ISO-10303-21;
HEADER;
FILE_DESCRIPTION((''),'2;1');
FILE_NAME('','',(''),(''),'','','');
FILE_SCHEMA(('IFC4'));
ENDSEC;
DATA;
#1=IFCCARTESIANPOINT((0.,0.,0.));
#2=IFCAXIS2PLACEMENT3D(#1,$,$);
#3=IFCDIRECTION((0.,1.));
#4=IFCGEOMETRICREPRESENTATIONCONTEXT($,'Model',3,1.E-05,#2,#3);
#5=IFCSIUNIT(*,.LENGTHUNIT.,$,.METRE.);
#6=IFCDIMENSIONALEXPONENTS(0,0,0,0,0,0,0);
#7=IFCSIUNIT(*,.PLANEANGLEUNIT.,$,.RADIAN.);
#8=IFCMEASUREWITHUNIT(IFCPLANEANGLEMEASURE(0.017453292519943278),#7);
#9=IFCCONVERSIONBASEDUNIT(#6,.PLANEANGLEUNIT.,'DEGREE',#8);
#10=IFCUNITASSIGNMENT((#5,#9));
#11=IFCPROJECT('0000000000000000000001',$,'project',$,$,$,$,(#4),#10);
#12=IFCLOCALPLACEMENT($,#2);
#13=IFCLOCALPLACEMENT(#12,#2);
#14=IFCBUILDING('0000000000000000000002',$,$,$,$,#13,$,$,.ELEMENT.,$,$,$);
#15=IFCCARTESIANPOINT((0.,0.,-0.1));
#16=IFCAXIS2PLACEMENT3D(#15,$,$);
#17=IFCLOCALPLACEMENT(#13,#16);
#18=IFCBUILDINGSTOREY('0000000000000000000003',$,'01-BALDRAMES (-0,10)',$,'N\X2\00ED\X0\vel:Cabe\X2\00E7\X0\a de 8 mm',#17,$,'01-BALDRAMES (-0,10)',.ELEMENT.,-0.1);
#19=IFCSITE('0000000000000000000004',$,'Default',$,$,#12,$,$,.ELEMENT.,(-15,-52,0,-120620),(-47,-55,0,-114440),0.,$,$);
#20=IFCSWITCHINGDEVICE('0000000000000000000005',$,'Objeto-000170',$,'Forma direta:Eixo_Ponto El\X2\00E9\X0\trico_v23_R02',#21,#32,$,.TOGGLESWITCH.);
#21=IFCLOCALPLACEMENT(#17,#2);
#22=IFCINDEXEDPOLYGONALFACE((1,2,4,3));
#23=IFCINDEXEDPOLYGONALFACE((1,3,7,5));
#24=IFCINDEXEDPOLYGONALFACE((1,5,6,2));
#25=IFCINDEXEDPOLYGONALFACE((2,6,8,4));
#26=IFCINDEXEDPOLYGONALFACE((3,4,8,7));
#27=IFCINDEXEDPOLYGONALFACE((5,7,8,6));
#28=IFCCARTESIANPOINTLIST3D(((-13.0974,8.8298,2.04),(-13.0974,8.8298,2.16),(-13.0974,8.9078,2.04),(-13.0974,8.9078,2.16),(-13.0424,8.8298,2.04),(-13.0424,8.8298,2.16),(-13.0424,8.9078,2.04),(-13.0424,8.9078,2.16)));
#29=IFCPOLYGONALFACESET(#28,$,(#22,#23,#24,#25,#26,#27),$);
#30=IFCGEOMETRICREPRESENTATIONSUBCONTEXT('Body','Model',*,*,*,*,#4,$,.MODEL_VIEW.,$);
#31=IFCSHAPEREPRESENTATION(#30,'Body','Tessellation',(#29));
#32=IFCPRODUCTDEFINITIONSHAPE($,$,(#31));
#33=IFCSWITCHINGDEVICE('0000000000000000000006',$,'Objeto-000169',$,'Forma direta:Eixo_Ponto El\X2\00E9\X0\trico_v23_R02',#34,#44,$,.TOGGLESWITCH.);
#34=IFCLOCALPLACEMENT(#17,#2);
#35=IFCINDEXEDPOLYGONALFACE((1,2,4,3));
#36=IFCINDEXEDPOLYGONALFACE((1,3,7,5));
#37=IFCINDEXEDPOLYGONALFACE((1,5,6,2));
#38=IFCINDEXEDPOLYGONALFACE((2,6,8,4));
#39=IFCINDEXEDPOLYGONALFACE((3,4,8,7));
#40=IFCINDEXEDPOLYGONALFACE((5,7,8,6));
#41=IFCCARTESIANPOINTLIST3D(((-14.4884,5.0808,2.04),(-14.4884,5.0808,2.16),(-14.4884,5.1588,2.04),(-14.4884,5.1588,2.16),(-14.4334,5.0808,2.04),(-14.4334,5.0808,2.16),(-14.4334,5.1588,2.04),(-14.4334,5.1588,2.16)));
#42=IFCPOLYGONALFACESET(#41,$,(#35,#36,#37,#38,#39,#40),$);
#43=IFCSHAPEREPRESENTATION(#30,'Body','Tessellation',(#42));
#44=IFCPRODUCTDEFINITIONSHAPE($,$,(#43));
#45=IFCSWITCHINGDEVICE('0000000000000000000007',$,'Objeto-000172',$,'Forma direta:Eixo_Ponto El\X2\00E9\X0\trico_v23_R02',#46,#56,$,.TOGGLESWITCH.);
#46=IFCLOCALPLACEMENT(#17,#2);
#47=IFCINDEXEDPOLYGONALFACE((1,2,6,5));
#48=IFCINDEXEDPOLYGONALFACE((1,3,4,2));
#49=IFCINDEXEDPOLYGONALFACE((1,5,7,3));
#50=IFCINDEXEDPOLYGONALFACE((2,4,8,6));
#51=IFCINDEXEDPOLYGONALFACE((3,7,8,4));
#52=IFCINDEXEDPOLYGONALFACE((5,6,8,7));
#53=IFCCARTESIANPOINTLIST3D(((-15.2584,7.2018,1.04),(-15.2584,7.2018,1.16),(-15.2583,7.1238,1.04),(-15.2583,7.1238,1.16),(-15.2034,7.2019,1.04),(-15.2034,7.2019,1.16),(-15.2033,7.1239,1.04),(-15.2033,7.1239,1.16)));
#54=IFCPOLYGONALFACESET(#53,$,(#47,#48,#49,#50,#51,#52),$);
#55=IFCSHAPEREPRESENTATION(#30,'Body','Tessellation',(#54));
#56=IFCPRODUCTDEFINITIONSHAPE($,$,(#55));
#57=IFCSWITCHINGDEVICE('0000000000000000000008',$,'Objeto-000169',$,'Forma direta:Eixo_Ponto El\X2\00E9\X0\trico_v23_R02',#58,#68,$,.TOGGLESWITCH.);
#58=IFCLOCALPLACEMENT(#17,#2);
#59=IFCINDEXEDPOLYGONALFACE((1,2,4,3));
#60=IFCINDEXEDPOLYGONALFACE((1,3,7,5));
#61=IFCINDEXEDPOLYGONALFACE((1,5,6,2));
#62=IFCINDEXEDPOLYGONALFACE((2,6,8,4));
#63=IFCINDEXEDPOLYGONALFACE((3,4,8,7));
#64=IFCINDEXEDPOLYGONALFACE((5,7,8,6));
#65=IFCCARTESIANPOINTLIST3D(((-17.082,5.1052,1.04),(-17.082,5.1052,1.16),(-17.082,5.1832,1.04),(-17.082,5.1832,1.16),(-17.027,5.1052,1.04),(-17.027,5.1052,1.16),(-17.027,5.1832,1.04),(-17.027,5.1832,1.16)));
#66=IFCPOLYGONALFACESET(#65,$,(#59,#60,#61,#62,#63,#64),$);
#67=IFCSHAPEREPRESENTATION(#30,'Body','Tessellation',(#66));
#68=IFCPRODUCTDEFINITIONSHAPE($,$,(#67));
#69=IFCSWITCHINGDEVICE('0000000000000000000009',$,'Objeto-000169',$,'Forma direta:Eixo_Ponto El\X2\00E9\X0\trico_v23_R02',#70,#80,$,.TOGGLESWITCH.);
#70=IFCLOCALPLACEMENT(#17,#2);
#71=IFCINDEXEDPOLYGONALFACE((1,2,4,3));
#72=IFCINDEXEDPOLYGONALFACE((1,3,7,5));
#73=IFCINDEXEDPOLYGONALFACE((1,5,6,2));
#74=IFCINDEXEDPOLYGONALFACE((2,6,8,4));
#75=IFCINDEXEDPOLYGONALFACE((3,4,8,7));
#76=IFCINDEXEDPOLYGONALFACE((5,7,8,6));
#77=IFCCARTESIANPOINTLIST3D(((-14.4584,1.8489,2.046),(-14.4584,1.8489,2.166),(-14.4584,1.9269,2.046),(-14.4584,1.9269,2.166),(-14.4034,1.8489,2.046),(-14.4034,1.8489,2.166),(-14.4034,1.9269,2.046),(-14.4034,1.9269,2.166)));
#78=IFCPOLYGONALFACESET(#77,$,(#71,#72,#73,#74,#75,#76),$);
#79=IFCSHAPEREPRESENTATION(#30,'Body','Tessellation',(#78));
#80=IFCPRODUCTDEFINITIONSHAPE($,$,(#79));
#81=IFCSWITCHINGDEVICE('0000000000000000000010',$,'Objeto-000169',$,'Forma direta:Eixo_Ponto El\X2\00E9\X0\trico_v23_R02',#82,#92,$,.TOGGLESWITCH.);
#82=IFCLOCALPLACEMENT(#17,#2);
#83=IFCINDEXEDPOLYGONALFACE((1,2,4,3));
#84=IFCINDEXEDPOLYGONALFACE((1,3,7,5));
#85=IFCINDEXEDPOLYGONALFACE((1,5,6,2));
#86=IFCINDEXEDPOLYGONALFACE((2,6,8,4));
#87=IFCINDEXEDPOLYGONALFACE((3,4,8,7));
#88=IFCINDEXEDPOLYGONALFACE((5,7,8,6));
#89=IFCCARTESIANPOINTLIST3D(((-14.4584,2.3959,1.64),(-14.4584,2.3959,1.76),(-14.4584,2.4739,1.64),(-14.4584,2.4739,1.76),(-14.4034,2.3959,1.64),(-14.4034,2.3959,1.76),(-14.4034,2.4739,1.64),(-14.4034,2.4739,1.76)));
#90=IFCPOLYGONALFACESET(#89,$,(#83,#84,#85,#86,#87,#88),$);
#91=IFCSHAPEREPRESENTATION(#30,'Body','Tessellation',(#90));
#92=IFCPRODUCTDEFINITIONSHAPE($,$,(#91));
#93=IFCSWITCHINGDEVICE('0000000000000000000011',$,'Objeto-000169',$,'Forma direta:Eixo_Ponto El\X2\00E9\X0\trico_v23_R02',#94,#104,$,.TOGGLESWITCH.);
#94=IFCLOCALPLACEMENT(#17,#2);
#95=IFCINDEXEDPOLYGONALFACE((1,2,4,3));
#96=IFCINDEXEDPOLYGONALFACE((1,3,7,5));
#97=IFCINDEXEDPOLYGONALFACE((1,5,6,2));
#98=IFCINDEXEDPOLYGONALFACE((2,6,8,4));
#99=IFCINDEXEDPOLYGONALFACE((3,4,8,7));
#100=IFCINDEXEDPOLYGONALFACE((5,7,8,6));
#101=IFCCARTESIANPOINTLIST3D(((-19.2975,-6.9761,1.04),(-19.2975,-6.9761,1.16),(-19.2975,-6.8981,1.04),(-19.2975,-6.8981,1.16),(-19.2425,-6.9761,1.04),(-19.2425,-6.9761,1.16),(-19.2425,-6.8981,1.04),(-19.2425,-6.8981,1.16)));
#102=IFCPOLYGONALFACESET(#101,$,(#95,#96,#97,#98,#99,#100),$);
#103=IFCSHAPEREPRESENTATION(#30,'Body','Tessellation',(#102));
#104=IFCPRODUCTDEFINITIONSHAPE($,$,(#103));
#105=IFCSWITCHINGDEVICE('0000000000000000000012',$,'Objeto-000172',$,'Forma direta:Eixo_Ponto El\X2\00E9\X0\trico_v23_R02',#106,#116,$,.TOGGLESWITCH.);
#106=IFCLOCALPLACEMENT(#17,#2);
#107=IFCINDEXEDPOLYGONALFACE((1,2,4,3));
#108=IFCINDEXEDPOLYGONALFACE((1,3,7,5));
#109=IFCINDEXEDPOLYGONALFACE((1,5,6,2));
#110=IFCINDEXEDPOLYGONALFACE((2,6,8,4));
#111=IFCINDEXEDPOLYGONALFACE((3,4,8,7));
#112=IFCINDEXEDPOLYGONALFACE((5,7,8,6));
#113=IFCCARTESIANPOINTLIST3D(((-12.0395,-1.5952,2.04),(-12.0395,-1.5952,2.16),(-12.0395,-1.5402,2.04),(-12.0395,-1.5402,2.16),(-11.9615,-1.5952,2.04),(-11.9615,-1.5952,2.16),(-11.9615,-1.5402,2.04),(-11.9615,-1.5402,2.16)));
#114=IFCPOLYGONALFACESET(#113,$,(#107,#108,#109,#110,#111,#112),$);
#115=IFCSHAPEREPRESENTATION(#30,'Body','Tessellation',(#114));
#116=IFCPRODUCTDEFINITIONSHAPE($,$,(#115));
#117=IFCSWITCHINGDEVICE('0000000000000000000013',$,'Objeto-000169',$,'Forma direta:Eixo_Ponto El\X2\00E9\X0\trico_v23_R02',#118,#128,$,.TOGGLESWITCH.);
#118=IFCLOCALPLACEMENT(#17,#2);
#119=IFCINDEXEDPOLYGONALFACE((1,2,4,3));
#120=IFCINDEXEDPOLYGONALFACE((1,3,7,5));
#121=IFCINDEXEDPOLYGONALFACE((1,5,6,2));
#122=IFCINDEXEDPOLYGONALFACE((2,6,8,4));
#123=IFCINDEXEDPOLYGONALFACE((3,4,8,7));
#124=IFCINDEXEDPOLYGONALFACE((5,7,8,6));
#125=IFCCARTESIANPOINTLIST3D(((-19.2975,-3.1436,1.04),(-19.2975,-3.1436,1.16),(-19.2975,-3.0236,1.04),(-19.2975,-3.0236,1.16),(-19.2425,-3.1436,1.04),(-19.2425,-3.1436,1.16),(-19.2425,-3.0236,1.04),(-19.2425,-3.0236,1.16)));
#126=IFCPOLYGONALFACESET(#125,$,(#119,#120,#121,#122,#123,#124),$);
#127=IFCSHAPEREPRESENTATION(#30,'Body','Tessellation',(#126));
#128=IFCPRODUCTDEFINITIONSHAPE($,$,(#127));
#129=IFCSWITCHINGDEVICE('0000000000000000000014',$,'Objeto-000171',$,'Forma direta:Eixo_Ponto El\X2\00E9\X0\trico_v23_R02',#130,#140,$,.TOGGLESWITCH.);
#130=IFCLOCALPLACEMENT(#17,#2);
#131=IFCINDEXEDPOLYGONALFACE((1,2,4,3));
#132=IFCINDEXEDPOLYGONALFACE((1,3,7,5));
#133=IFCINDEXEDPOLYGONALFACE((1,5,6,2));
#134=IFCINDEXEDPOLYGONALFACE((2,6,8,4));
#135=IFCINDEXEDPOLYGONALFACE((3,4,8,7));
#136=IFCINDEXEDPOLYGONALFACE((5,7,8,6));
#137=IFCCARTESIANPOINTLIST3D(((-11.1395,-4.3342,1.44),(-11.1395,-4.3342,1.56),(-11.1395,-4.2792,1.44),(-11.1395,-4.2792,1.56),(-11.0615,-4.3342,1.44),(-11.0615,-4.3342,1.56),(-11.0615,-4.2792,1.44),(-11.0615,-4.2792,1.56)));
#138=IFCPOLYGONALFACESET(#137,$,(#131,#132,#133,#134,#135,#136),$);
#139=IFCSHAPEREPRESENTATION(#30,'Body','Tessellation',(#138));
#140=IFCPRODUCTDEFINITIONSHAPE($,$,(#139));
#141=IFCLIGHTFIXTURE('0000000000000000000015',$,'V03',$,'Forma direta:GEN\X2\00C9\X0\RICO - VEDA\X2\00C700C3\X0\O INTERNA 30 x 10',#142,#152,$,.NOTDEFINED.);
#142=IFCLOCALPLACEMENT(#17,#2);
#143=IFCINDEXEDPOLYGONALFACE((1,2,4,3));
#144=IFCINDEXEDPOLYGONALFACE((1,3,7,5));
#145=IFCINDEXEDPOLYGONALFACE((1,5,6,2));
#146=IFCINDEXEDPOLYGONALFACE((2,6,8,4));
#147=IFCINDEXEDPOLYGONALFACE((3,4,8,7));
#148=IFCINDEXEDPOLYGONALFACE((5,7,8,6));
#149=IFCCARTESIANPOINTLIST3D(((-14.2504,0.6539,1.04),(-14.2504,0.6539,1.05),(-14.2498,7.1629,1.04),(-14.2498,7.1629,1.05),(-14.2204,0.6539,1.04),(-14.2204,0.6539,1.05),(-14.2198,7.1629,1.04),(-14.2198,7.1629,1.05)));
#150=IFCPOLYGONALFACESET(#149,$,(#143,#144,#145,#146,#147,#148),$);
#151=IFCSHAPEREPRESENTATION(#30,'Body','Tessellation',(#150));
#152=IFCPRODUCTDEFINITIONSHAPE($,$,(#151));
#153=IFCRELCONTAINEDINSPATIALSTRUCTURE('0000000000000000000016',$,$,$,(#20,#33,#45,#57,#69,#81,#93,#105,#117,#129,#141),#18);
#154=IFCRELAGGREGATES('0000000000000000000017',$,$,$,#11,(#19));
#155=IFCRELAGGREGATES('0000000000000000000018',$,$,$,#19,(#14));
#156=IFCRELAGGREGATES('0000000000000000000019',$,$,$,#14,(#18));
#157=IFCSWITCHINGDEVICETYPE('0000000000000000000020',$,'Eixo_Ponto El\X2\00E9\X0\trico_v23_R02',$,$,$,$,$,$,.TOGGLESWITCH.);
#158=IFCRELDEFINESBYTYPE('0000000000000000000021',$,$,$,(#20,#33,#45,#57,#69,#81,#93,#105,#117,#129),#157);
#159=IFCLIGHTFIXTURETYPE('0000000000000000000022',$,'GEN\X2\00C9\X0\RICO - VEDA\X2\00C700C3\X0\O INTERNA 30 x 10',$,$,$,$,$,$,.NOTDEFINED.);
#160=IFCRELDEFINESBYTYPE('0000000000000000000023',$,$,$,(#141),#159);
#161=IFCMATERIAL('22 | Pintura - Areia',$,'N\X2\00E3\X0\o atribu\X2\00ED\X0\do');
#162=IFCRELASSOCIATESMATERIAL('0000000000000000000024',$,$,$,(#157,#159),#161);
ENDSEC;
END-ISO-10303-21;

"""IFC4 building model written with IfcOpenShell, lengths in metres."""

from ifc_helpers import new_model, entity, si_unit, converted_unit, direction, frame, origin, place, context, subcontext, project, spatial, indexed_curve, outline, extrude, material, type_object, element, save


model = new_model("IFC4")

# Units and contexts
model_context = context("Model", 3, precision=1e-05, world=origin(), true_north=direction((0.0, 1.0)))
body_context = subcontext(model_context, "Body", "Model", "MODEL_VIEW")
ifc_project = project(units=[si_unit("LENGTHUNIT", "METRE"), converted_unit("PLANEANGLEUNIT", "DEGREE", entity("IfcPlaneAngleMeasure", 0.017453292519943278), si_unit("PLANEANGLEUNIT", "RADIAN"), dimensions=[0, 0, 0, 0, 0, 0, 0])], contexts=[model_context])

# Site, building, storey
site_placement = place(None, origin())
site = spatial("IfcSite", under=ifc_project, at=site_placement, Name="Default", CompositionType="ELEMENT", RefLatitude=(-15, -52, 0, -120620), RefLongitude=(-47, -55, 0, -114440), RefElevation=0.0)
building_placement = place(site_placement, origin())
building = spatial("IfcBuilding", under=site, at=building_placement, CompositionType="ELEMENT")
storey_placement = place(building_placement, frame((0.0, 0.0, -0.1)))
storey = spatial("IfcBuildingStorey", under=building, at=storey_placement, Name="01-BALDRAMES (-0,10)", ObjectType="Nível:Cabeça de 8 mm", LongName="01-BALDRAMES (-0,10)", CompositionType="ELEMENT", Elevation=-0.1)

# Switching devices
ifc_material_1 = material(Name="22 | Pintura - Areia", Category="Não atribuído")
switching_device_type_1 = type_object("IfcSwitchingDeviceType", Name="Eixo_Ponto Elétrico_v23_R02", PredefinedType="TOGGLESWITCH", material=ifc_material_1)
switching_device_1_placement = place(storey_placement, origin())
element("IfcSwitchingDevice", 1, at=switching_device_1_placement, inside=storey, type_object=switching_device_type_1, Name="Objeto-000170", ObjectType="Forma direta:Eixo_Ponto Elétrico_v23_R02", PredefinedType="TOGGLESWITCH", context=body_context, shape_type="SweptSolid", body=[
    extrude(outline(indexed_curve([(-0.0275, -0.039), (0.0275, -0.039), (0.0275, 0.039), (-0.0275, 0.039), (-0.0275, -0.039)], self_intersect=False)), frame((-13.0699, 8.8688, 2.04), z_axis=(0.0, 0.0, 1.0), x_axis=(-1.0, 0.000013, 0.0)), (0.0, 0.0, 1.0), 0.12),
])
switching_device_2_placement = place(storey_placement, origin())
element("IfcSwitchingDevice", 2, at=switching_device_2_placement, inside=storey, type_object=switching_device_type_1, Name="Objeto-000169", ObjectType="Forma direta:Eixo_Ponto Elétrico_v23_R02", PredefinedType="TOGGLESWITCH", context=body_context, shape_type="SweptSolid", body=[
    extrude(outline(indexed_curve([(-0.039, -0.0275), (0.039, -0.0275), (0.039, 0.0275), (-0.039, 0.0275), (-0.039, -0.0275)], self_intersect=False)), frame((-14.4609, 5.1198, 2.04), z_axis=(0.0, 0.0, 1.0), x_axis=(-0.000013, -1.0, 0.0)), (0.0, 0.0, 1.0), 0.12),
])
switching_device_3_placement = place(storey_placement, origin())
element("IfcSwitchingDevice", 3, at=switching_device_3_placement, inside=storey, type_object=switching_device_type_1, Name="Objeto-000172", ObjectType="Forma direta:Eixo_Ponto Elétrico_v23_R02", PredefinedType="TOGGLESWITCH", context=body_context, shape_type="SweptSolid", body=[
    extrude(outline(indexed_curve([(-0.0275, -0.039), (0.0275, -0.039), (0.0275, 0.039), (-0.0275, 0.039), (-0.0275, -0.039)], self_intersect=False)), frame((-15.2308, 7.1629, 1.04), z_axis=(0.0, 0.0, 1.0), x_axis=(1.0, 0.000186, 0.0)), (0.0, 0.0, 1.0), 0.12),
])
switching_device_4_placement = place(storey_placement, origin())
element("IfcSwitchingDevice", 4, at=switching_device_4_placement, inside=storey, type_object=switching_device_type_1, Name="Objeto-000169", ObjectType="Forma direta:Eixo_Ponto Elétrico_v23_R02", PredefinedType="TOGGLESWITCH", context=body_context, shape_type="SweptSolid", body=[
    extrude(outline(indexed_curve([(-0.0275, -0.039), (0.0275, -0.039), (0.0275, 0.039), (-0.0275, 0.039), (-0.0275, -0.039)], self_intersect=False)), frame((-17.0545, 5.1442, 1.04), z_axis=(0.0, 0.0, 1.0), x_axis=(-1.0, 0.000013, 0.0)), (0.0, 0.0, 1.0), 0.12),
])
switching_device_5_placement = place(storey_placement, origin())
element("IfcSwitchingDevice", 5, at=switching_device_5_placement, inside=storey, type_object=switching_device_type_1, Name="Objeto-000169", ObjectType="Forma direta:Eixo_Ponto Elétrico_v23_R02", PredefinedType="TOGGLESWITCH", context=body_context, shape_type="SweptSolid", body=[
    extrude(outline(indexed_curve([(-0.0275, -0.039), (0.0275, -0.039), (0.0275, 0.039), (-0.0275, 0.039), (-0.0275, -0.039)], self_intersect=False)), frame((-14.4309, 1.8879, 2.046)), (0.0, 0.0, 1.0), 0.12),
])
switching_device_6_placement = place(storey_placement, origin())
element("IfcSwitchingDevice", 6, at=switching_device_6_placement, inside=storey, type_object=switching_device_type_1, Name="Objeto-000169", ObjectType="Forma direta:Eixo_Ponto Elétrico_v23_R02", PredefinedType="TOGGLESWITCH", context=body_context, shape_type="SweptSolid", body=[
    extrude(outline(indexed_curve([(-0.039, -0.0275), (0.039, -0.0275), (0.039, 0.0275), (-0.039, 0.0275), (-0.039, -0.0275)], self_intersect=False)), frame((-14.4309, 2.4349, 1.64), z_axis=(0.0, 0.0, 1.0), x_axis=(-0.000013, -1.0, 0.0)), (0.0, 0.0, 1.0), 0.12),
])
switching_device_7_placement = place(storey_placement, origin())
element("IfcSwitchingDevice", 7, at=switching_device_7_placement, inside=storey, type_object=switching_device_type_1, Name="Objeto-000169", ObjectType="Forma direta:Eixo_Ponto Elétrico_v23_R02", PredefinedType="TOGGLESWITCH", context=body_context, shape_type="SweptSolid", body=[
    extrude(outline(indexed_curve([(-0.0275, -0.039), (0.0275, -0.039), (0.0275, 0.039), (-0.0275, 0.039), (-0.0275, -0.039)], self_intersect=False)), frame((-19.27, -6.9371, 1.04), z_axis=(0.0, 0.0, 1.0), x_axis=(-1.0, 0.000015, 0.0)), (0.0, 0.0, 1.0), 0.12),
])
switching_device_8_placement = place(storey_placement, origin())
element("IfcSwitchingDevice", 8, at=switching_device_8_placement, inside=storey, type_object=switching_device_type_1, Name="Objeto-000172", ObjectType="Forma direta:Eixo_Ponto Elétrico_v23_R02", PredefinedType="TOGGLESWITCH", context=body_context, shape_type="SweptSolid", body=[
    extrude(outline(indexed_curve([(-0.0275, -0.039), (0.0275, -0.039), (0.0275, 0.039), (-0.0275, 0.039), (-0.0275, -0.039)], self_intersect=False)), frame((-12.0005, -1.5677, 2.04), z_axis=(0.0, 0.0, 1.0), x_axis=(0.000013, 1.0, 0.0)), (0.0, 0.0, 1.0), 0.12),
])
switching_device_9_placement = place(storey_placement, origin())
element("IfcSwitchingDevice", 9, at=switching_device_9_placement, inside=storey, type_object=switching_device_type_1, Name="Objeto-000169", ObjectType="Forma direta:Eixo_Ponto Elétrico_v23_R02", PredefinedType="TOGGLESWITCH", context=body_context, shape_type="SweptSolid", body=[
    extrude(outline(indexed_curve([(-0.0275, -0.06), (0.0275, -0.06), (0.0275, 0.06), (-0.0275, 0.06), (-0.0275, -0.06)], self_intersect=False)), frame((-19.27, -3.0836, 1.04), z_axis=(0.0, 0.0, 1.0), x_axis=(-1.0, 0.000013, 0.0)), (0.0, 0.0, 1.0), 0.12),
])
switching_device_10_placement = place(storey_placement, origin())
element("IfcSwitchingDevice", 10, at=switching_device_10_placement, inside=storey, type_object=switching_device_type_1, Name="Objeto-000171", ObjectType="Forma direta:Eixo_Ponto Elétrico_v23_R02", PredefinedType="TOGGLESWITCH", context=body_context, shape_type="SweptSolid", body=[
    extrude(outline(indexed_curve([(-0.0275, -0.039), (0.0275, -0.039), (0.0275, 0.039), (-0.0275, 0.039), (-0.0275, -0.039)], self_intersect=False)), frame((-11.1005, -4.3067, 1.44), z_axis=(0.0, 0.0, 1.0), x_axis=(-0.000052, -1.0, 0.0)), (0.0, 0.0, 1.0), 0.12),
])

# Light fixture
light_fixture_type_1 = type_object("IfcLightFixtureType", Name="GENÉRICO - VEDAÇÃO INTERNA 30 x 10", PredefinedType="NOTDEFINED", material=ifc_material_1)
light_fixture_1_placement = place(storey_placement, origin())
element("IfcLightFixture", 11, at=light_fixture_1_placement, inside=storey, type_object=light_fixture_type_1, Name="V03", ObjectType="Forma direta:GENÉRICO - VEDAÇÃO INTERNA 30 x 10", PredefinedType="NOTDEFINED", context=body_context, shape_type="SweptSolid", body=[
    extrude(outline(indexed_curve([(-3.2545, -0.015), (3.2545, -0.015), (3.2545, 0.015), (-3.2545, 0.015), (-3.2545, -0.015)], self_intersect=False)), frame((-14.2351, 3.9084, 1.04), z_axis=(0.0, 0.0, 1.0), x_axis=(0.000096, 1.0, 0.0)), (0.0, 0.0, 1.0), 0.01),
])

save(model, "model.ifc")
